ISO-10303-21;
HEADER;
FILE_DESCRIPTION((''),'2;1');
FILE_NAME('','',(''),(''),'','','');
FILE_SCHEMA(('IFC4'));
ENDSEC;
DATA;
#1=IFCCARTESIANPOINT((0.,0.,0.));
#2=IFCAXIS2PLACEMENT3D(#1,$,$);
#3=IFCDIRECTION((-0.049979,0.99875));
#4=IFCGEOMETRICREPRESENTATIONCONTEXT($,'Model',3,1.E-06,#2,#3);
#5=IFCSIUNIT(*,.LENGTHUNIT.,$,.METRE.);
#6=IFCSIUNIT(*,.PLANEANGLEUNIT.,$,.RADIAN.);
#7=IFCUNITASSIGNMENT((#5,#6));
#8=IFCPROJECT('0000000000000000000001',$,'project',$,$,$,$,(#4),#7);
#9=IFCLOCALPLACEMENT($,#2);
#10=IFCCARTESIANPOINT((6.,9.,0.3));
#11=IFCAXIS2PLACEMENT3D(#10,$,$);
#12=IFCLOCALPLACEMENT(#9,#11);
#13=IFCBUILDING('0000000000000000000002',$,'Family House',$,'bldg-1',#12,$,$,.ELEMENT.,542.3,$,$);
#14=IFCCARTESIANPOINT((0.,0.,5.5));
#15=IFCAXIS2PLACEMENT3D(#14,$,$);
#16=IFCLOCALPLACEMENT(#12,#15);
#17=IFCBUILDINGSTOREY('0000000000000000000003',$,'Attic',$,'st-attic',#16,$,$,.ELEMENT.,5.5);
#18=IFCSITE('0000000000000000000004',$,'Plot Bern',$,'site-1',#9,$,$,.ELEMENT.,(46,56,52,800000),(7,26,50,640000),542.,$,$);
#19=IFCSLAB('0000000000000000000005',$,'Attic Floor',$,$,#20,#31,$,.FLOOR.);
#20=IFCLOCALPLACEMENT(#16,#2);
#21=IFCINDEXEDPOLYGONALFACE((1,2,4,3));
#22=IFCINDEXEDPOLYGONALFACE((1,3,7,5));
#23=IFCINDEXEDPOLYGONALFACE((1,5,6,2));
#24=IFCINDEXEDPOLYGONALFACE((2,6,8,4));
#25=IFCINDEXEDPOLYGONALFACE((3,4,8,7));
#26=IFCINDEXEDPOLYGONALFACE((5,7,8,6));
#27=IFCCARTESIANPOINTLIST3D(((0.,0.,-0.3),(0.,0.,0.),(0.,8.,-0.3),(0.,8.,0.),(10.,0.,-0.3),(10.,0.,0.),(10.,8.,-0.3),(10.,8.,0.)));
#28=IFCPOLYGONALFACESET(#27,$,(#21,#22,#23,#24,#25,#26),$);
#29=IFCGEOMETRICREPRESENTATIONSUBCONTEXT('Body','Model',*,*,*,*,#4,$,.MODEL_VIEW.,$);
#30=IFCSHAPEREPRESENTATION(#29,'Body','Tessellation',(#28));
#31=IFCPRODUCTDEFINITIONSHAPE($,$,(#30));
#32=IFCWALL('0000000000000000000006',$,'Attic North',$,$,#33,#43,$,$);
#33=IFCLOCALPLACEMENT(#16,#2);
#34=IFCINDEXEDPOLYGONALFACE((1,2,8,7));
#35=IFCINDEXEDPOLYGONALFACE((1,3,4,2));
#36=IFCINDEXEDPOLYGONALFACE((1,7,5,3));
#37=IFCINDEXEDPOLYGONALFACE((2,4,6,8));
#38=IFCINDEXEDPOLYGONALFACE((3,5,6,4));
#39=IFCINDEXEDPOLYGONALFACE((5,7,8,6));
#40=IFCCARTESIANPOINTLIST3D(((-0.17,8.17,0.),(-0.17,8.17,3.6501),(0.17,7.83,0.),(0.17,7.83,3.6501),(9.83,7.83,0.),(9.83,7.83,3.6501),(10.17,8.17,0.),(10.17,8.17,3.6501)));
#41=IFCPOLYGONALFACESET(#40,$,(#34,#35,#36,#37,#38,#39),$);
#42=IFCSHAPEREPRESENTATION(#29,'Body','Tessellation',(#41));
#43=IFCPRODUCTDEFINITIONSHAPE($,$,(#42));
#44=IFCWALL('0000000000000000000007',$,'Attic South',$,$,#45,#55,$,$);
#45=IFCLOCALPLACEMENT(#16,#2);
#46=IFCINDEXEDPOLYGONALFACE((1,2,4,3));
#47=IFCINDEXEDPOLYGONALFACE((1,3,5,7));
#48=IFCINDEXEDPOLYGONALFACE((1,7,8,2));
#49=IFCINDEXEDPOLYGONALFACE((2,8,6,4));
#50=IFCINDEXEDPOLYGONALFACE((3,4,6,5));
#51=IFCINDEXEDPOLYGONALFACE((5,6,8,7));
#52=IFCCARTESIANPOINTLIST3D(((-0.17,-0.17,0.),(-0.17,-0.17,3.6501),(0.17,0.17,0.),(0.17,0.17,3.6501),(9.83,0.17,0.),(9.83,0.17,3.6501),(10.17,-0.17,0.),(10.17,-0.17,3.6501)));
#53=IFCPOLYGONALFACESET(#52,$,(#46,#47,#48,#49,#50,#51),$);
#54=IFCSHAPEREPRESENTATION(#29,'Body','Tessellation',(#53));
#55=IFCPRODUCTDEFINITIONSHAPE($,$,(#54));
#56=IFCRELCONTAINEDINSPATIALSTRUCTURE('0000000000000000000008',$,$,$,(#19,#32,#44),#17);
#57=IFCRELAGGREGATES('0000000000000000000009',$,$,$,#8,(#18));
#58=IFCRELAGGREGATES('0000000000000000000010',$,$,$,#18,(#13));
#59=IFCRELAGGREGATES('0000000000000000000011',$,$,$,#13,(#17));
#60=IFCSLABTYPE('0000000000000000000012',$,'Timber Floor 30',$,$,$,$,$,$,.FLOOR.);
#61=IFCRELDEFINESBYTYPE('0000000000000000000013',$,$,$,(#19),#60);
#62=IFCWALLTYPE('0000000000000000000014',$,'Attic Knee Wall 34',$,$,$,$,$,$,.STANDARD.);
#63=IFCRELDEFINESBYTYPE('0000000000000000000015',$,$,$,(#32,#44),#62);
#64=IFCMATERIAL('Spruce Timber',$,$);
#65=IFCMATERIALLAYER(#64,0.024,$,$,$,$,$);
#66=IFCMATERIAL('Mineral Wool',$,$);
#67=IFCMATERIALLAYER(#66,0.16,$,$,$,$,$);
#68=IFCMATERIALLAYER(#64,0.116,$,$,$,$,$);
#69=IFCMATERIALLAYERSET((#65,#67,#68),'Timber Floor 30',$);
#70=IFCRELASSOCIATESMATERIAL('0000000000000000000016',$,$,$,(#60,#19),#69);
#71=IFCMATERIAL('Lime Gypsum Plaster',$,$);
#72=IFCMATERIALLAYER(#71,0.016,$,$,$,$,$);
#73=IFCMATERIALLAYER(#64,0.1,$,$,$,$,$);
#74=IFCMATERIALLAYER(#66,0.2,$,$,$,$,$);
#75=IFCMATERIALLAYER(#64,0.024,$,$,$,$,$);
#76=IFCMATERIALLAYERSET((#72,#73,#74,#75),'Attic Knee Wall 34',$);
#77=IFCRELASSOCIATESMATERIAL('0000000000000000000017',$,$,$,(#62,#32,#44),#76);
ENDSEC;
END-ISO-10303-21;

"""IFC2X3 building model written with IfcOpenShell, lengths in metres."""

from ifc_helpers import new_model, si_unit, direction, frame, origin, place, context, subcontext, project, spatial, polyline, outline, extrude, material, layer, layer_set, layer_usage, type_object, element, save


model = new_model("IFC2X3")

# Units and contexts
model_context = context("Model", 3, precision=1e-06, world=origin(), true_north=direction((-0.049979, 0.99875)))
body_context = subcontext(model_context, "Body", "Model", "MODEL_VIEW")
ifc_project = project(units=[si_unit("LENGTHUNIT", "METRE"), si_unit("PLANEANGLEUNIT", "RADIAN")], contexts=[model_context])

# Site, building, storey
site_placement = place(None, origin())
site = spatial("IfcSite", under=ifc_project, at=site_placement, Name="Plot Bern", ObjectType="site-1", CompositionType="ELEMENT", RefLatitude=(46, 56, 52, 800000), RefLongitude=(7, 26, 50, 640000), RefElevation=542.0)
building_placement = place(site_placement, frame((6.0, 9.0, 0.3)))
building = spatial("IfcBuilding", under=site, at=building_placement, Name="Family House", ObjectType="bldg-1", CompositionType="ELEMENT", ElevationOfRefHeight=542.3)
storey_placement = place(building_placement, frame((0.0, 0.0, 5.5)))
storey = spatial("IfcBuildingStorey", under=building, at=storey_placement, Name="Attic", ObjectType="st-attic", CompositionType="ELEMENT", Elevation=5.5)

# Slab
ifc_material_1 = material(Name="Spruce Timber")
ifc_layer_1 = layer(ifc_material_1, 0.024)
ifc_material_2 = material(Name="Mineral Wool")
ifc_layer_2 = layer(ifc_material_2, 0.16)
ifc_layer_3 = layer(ifc_material_1, 0.116)
ifc_layer_set_1 = layer_set([ifc_layer_1, ifc_layer_2, ifc_layer_3], Name="Timber Floor 30")
ifc_layer_usage_1 = layer_usage(ifc_layer_set_1, "AXIS3", "NEGATIVE", 0.3)
slab_type = type_object("IfcSlabType", Name="Timber Floor 30", PredefinedType="FLOOR", material=ifc_layer_set_1)
slab_placement = place(storey_placement, frame((0.0, 0.0, -0.3)))
element("IfcSlab", 1, at=slab_placement, inside=storey, type_object=slab_type, material=ifc_layer_usage_1, Name="Attic Floor", PredefinedType="FLOOR", context=body_context, shape_type="SweptSolid", body=[
    extrude(outline(polyline([(0.0, 0.0), (10.0, 0.0), (10.0, 8.0), (0.0, 8.0), (0.0, 0.0)])), origin(), (0.0, 0.0, 1.0), 0.3),
])

# Walls
ifc_material_3 = material(Name="Lime Gypsum Plaster")
ifc_layer_4 = layer(ifc_material_3, 0.016)
ifc_layer_5 = layer(ifc_material_1, 0.1)
ifc_layer_6 = layer(ifc_material_2, 0.2)
ifc_layer_7 = layer(ifc_material_1, 0.024)
ifc_layer_set_2 = layer_set([ifc_layer_4, ifc_layer_5, ifc_layer_6, ifc_layer_7], Name="Attic Knee Wall 34")
ifc_layer_usage_2 = layer_usage(ifc_layer_set_2, "AXIS2", "NEGATIVE", 0.17)
wall_type = type_object("IfcWallType", Name="Attic Knee Wall 34", PredefinedType="STANDARD", material=ifc_layer_set_2)
wall_1_placement = place(storey_placement, origin())
element("IfcWall", 2, at=wall_1_placement, inside=storey, type_object=wall_type, material=ifc_layer_usage_2, Name="Attic North", context=body_context, shape_type="SweptSolid", body=[
    extrude(outline(polyline([(10.17, 8.17), (-0.17, 8.17), (0.17, 7.83), (9.83, 7.83), (10.17, 8.17)])), origin(), (0.0, 0.0, 1.0), 3.6501),
])
ifc_layer_usage_3 = layer_usage(ifc_layer_set_2, "AXIS2", "NEGATIVE", 0.17)
wall_2_placement = place(storey_placement, origin())
element("IfcWall", 3, at=wall_2_placement, inside=storey, type_object=wall_type, material=ifc_layer_usage_3, Name="Attic South", context=body_context, shape_type="SweptSolid", body=[
    extrude(outline(polyline([(-0.17, -0.17), (10.17, -0.17), (9.83, 0.17), (0.17, 0.17), (-0.17, -0.17)])), origin(), (0.0, 0.0, 1.0), 3.6501),
])

save(model, "model.ifc")
